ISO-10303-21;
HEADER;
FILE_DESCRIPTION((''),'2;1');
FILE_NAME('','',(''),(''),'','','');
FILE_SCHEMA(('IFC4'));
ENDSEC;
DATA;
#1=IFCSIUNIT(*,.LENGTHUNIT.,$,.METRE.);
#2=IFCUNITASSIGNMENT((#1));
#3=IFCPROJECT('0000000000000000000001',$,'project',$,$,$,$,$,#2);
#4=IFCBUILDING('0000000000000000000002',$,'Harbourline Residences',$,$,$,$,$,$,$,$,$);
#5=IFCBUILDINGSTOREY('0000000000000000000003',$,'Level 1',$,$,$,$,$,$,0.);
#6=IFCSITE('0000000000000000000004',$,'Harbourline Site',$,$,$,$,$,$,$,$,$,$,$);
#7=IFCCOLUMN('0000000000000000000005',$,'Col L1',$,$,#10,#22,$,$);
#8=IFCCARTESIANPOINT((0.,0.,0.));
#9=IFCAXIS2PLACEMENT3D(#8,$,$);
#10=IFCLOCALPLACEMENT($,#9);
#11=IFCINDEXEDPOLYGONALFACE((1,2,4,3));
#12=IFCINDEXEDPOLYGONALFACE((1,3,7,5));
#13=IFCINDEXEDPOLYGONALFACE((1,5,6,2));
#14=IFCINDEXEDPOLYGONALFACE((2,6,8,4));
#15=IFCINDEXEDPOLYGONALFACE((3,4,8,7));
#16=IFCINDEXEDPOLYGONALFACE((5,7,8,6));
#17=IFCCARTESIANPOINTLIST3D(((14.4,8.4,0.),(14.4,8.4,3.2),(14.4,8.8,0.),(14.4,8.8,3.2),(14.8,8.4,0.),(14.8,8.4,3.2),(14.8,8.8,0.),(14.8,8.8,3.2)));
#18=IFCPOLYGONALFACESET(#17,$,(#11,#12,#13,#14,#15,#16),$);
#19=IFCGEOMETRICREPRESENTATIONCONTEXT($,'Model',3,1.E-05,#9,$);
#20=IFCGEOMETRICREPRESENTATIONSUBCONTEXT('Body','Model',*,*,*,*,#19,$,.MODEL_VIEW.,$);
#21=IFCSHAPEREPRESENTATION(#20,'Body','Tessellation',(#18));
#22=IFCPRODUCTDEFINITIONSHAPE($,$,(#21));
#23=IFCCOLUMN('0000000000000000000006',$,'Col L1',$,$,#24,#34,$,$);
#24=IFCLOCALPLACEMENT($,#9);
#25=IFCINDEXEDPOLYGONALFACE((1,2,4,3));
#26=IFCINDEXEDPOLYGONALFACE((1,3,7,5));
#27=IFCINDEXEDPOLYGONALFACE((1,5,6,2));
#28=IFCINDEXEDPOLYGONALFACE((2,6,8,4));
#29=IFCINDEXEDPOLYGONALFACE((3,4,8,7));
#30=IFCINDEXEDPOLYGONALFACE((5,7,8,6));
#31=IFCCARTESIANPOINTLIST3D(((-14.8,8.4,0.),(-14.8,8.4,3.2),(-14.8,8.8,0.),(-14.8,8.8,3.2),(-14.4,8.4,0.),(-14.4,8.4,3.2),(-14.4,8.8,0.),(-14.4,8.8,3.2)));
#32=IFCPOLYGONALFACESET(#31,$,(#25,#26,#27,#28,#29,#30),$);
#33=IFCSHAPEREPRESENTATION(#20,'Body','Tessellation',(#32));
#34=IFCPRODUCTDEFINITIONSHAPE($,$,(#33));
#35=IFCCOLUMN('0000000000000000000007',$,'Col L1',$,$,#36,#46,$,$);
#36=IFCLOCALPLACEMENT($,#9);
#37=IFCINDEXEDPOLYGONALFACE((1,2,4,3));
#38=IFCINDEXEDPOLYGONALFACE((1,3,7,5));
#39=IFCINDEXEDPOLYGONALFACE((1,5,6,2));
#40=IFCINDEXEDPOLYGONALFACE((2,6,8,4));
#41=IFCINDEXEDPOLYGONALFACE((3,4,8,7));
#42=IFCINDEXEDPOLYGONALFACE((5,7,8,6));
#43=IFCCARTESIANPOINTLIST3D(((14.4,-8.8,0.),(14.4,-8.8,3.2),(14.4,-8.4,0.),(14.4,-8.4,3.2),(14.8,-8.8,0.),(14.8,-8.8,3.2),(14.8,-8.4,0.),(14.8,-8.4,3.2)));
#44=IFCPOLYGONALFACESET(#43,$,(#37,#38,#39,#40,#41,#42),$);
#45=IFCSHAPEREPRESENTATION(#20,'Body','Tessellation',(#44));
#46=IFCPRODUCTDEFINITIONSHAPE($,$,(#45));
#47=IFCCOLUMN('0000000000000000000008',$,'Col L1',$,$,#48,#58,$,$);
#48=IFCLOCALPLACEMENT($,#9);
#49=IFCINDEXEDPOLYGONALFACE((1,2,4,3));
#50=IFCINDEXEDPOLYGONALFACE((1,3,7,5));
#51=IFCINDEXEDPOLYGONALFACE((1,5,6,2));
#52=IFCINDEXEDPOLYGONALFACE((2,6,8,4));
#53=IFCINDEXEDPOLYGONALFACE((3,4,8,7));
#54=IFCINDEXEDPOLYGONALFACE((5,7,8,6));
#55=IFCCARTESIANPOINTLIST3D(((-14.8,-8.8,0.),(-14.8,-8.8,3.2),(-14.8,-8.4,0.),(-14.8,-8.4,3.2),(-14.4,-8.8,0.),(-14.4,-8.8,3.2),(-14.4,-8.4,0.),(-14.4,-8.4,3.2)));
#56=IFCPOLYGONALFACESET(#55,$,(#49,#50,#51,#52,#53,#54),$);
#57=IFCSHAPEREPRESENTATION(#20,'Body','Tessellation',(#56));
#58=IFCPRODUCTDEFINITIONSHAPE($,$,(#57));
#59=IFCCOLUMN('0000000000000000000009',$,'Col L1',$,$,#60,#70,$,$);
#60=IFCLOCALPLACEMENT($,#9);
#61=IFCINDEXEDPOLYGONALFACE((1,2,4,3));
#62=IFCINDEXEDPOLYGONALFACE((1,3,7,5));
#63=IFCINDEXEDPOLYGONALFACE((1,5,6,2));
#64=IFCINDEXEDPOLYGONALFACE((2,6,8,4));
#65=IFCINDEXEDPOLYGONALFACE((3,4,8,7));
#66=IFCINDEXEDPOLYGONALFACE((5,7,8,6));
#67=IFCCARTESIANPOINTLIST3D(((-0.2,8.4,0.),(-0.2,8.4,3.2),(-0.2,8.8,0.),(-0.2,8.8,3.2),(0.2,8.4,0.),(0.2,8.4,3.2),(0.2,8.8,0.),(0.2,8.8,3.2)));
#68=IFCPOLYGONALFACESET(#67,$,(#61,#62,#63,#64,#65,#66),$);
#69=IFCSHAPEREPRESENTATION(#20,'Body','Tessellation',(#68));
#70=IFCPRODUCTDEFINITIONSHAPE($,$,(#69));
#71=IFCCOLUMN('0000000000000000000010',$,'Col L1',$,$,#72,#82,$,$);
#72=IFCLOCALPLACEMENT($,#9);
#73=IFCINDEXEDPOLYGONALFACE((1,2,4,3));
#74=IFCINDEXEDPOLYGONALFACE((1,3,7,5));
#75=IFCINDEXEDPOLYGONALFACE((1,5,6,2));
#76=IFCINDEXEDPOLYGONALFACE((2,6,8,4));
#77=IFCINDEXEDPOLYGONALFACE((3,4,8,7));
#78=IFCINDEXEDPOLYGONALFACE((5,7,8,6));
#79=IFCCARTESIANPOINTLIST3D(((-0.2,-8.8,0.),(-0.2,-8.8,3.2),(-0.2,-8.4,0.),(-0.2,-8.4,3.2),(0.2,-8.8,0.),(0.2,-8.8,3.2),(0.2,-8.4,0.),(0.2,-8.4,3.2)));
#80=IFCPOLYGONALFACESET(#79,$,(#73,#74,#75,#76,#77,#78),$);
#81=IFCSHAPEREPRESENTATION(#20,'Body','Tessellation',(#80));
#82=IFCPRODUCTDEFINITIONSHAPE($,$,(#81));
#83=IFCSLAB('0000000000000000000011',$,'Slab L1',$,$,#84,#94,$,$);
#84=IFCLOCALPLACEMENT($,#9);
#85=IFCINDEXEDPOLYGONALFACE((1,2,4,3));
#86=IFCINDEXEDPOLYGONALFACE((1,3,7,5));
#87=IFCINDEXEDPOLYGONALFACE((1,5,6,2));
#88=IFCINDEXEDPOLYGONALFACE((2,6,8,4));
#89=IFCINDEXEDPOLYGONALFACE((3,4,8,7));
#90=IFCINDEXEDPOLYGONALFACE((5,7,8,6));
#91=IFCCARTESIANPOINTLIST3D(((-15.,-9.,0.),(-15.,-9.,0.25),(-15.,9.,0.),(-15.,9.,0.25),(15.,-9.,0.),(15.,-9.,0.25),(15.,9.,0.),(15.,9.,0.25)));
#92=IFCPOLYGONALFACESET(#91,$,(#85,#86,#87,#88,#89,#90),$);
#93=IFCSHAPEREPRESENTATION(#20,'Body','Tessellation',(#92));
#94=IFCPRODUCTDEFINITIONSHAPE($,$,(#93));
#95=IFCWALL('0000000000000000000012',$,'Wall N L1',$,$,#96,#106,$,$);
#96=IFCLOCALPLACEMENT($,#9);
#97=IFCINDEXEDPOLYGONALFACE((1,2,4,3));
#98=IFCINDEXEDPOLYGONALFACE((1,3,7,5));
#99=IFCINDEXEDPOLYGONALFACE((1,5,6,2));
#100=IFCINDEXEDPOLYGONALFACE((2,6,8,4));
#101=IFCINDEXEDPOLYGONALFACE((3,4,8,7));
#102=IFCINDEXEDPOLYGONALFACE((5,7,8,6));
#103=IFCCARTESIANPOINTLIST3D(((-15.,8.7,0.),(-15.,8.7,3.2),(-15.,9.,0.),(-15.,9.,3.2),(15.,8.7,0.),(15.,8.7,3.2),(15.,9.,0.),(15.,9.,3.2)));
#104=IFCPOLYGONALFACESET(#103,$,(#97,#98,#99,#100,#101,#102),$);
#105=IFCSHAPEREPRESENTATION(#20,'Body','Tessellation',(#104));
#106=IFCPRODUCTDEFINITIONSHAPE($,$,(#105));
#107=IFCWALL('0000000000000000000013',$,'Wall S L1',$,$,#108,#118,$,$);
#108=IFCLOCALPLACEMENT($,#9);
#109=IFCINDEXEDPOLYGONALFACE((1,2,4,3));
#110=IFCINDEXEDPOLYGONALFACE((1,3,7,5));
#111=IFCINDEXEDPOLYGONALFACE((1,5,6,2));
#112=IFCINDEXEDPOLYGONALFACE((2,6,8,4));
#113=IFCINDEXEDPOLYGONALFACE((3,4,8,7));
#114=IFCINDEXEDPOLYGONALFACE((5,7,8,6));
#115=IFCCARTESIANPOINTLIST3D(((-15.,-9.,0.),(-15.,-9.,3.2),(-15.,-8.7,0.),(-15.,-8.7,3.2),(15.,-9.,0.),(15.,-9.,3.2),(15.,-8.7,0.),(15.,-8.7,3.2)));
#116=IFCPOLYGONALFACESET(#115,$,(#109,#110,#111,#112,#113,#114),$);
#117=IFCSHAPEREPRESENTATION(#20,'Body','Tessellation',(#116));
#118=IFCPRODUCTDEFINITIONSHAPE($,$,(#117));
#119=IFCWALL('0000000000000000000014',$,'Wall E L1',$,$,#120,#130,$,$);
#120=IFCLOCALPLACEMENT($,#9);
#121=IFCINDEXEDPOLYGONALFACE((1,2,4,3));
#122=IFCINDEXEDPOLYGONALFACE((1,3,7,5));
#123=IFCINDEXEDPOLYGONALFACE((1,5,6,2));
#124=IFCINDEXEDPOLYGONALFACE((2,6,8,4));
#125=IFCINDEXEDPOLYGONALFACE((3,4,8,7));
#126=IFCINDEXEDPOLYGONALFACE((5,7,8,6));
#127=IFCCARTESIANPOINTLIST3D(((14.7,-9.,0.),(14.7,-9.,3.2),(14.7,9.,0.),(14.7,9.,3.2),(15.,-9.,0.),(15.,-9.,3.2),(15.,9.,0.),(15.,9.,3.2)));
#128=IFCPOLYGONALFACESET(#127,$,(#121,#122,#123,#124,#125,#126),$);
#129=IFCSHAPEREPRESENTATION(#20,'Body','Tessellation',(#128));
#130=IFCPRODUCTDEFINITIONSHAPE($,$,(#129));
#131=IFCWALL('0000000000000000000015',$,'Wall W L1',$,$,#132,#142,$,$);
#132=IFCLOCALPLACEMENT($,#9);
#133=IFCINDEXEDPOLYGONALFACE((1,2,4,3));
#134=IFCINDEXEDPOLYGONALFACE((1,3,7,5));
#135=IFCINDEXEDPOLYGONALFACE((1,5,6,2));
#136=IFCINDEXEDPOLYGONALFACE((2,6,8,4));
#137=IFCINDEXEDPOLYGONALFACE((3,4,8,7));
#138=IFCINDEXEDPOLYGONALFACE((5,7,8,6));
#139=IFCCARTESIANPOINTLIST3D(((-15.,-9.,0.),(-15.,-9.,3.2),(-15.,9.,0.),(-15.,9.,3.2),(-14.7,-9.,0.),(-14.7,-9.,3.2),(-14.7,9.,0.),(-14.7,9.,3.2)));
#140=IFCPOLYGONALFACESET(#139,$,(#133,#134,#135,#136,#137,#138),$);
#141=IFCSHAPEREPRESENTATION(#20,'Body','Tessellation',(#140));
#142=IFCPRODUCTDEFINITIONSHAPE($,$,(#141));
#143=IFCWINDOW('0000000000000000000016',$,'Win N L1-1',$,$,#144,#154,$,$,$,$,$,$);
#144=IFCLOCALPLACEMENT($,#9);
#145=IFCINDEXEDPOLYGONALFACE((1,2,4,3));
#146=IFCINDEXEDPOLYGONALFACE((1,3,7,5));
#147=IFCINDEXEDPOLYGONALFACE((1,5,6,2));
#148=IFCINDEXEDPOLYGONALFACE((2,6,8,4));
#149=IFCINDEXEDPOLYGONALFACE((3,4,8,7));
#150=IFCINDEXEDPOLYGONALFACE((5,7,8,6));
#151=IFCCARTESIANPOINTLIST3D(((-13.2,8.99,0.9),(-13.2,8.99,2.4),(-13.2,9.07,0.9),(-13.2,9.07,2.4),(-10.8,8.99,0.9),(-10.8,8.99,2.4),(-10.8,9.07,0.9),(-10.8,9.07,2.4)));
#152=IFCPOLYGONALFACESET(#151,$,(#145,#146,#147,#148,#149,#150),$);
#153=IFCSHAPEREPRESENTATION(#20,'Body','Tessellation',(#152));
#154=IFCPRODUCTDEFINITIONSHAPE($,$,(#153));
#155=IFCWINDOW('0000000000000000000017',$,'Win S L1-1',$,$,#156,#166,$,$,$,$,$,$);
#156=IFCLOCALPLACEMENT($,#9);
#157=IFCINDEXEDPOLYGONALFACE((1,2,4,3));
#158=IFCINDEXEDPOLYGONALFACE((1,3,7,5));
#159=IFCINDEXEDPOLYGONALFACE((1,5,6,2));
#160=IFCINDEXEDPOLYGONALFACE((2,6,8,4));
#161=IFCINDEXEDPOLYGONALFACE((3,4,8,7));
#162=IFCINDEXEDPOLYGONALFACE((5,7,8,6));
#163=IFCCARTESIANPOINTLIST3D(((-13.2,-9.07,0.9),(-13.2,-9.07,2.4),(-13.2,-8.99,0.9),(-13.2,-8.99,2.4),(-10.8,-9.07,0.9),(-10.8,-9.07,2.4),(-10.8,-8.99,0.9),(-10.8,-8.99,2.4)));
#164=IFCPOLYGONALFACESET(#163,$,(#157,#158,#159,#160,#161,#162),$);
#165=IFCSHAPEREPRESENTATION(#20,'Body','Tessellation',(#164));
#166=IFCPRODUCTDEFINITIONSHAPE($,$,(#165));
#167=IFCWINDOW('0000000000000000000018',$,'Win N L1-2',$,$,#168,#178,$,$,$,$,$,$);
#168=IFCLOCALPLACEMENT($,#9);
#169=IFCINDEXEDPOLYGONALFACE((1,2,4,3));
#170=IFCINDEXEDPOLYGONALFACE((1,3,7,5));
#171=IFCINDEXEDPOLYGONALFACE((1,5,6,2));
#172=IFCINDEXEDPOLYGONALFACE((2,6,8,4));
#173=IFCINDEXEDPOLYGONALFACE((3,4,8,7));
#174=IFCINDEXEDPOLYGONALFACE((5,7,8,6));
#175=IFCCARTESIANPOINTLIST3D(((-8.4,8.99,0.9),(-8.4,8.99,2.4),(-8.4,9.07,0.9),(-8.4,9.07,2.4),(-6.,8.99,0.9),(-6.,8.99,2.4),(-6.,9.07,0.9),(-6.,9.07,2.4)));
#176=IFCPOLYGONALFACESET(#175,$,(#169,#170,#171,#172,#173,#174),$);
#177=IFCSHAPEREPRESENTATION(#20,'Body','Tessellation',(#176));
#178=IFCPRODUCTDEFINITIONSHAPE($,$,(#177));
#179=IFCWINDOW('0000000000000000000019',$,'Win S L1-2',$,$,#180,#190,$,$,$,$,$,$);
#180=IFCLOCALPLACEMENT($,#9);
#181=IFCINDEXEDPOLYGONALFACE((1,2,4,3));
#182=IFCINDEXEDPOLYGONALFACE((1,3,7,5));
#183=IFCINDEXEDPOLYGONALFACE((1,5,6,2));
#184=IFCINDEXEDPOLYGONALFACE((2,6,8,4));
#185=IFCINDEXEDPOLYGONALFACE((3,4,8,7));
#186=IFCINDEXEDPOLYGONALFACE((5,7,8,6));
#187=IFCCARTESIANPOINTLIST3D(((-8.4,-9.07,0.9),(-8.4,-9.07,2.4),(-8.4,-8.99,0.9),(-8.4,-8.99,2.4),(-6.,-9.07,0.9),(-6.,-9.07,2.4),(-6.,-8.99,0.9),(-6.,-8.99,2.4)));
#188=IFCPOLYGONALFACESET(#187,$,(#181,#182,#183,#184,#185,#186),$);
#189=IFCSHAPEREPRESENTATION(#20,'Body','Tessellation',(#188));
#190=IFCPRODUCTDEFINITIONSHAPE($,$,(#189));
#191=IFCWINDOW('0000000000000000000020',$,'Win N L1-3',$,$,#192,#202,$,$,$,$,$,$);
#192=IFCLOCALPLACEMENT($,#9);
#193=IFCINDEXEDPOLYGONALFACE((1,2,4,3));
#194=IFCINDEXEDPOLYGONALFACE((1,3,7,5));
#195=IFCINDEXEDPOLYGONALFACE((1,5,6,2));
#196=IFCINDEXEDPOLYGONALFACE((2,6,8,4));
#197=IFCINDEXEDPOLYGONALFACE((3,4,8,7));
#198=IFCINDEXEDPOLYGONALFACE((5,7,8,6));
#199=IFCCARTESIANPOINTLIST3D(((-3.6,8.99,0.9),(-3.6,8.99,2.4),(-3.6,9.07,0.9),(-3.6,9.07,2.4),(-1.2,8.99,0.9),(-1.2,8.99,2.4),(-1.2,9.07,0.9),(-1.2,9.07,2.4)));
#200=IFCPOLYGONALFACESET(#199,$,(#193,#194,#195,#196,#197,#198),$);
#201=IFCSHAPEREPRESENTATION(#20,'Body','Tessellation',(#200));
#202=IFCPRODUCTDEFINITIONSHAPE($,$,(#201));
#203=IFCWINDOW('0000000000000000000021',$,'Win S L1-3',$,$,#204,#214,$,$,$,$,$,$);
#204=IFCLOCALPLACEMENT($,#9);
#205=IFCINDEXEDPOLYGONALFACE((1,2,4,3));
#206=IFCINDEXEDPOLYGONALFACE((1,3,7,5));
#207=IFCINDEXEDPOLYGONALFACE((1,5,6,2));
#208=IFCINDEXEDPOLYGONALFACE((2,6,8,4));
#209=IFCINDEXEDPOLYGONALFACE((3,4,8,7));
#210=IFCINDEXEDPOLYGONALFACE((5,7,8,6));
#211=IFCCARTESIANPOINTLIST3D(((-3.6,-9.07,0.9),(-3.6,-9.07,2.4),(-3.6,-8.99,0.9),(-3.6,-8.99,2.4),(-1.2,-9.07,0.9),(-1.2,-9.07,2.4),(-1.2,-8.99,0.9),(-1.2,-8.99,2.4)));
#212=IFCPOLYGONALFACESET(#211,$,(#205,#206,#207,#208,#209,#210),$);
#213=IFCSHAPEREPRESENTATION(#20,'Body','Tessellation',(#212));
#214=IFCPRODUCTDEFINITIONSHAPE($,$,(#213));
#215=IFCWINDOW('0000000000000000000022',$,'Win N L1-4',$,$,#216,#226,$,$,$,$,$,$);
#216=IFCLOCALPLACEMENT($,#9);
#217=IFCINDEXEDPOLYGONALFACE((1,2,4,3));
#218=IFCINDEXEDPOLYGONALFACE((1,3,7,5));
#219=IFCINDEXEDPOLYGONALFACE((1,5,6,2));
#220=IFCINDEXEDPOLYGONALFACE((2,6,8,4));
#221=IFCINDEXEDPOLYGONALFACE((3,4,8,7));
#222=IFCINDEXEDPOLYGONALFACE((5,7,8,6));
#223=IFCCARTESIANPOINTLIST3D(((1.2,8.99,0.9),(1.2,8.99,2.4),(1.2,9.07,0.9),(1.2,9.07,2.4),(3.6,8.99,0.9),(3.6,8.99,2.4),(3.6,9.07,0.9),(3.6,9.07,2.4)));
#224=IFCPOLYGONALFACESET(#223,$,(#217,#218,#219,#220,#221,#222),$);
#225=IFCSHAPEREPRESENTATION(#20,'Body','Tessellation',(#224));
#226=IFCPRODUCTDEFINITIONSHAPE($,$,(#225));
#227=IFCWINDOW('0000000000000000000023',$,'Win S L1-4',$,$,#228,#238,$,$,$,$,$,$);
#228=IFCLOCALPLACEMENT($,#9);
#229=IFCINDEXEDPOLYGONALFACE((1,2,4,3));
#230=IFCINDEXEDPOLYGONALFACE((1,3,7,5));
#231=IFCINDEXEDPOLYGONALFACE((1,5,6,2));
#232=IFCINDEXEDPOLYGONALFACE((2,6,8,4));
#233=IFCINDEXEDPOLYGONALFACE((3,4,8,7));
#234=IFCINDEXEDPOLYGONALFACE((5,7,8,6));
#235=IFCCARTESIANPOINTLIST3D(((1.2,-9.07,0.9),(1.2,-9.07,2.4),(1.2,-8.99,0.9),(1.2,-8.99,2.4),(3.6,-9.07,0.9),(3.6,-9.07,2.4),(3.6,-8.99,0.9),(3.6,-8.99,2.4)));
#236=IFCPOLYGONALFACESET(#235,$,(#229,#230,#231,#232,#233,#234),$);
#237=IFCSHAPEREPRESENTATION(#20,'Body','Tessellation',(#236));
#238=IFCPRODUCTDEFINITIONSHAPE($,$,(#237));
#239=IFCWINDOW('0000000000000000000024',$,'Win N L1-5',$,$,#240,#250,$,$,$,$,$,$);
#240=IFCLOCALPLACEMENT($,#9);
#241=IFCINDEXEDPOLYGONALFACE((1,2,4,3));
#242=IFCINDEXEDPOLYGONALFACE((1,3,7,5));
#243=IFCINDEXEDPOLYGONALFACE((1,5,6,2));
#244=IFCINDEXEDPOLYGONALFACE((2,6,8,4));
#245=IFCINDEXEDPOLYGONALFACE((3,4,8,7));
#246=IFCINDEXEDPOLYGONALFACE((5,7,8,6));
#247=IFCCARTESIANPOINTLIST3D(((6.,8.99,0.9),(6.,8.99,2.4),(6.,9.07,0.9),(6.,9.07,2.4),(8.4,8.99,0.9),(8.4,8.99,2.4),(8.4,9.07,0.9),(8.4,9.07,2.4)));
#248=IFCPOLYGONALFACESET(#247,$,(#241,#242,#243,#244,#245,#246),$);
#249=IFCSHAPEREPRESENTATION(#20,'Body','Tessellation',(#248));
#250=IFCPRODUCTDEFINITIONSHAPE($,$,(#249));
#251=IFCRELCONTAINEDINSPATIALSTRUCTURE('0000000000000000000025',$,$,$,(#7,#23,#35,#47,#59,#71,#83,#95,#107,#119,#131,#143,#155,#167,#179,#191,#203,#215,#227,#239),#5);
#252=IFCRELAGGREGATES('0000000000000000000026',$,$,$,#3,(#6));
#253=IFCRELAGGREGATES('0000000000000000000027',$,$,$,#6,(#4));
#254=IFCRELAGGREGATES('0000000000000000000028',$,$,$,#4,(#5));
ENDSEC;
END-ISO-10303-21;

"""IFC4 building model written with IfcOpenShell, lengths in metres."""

from ifc_helpers import new_model, si_unit, frame, frame_2d, origin, origin_2d, context, subcontext, project, spatial, rectangle, extrude, element, save


model = new_model("IFC4")

# Units and contexts
model_context = context("Model", 3, precision=1e-05, world=origin())
body_context = subcontext(model_context, "Body", "Model", "MODEL_VIEW")
ifc_project = project(units=[si_unit("LENGTHUNIT", "METRE")])

# Site, building, storey
site = spatial("IfcSite", under=ifc_project, Name="Harbourline Site")
building = spatial("IfcBuilding", under=site, Name="Harbourline Residences")
storey = spatial("IfcBuildingStorey", under=building, Name="Level 1", Elevation=0.0)

# Columns
element("IfcColumn", 1, inside=storey, Name="Col L1", context=body_context, shape_type="SweptSolid", body=[
    extrude(rectangle(XDim=0.4, YDim=0.4, at=frame_2d((14.6, 8.6))), origin(), (0.0, 0.0, 1.0), 3.2),
])
element("IfcColumn", 2, inside=storey, Name="Col L1", context=body_context, shape_type="SweptSolid", body=[
    extrude(rectangle(XDim=0.4, YDim=0.4, at=frame_2d((-14.6, 8.6))), origin(), (0.0, 0.0, 1.0), 3.2),
])
element("IfcColumn", 3, inside=storey, Name="Col L1", context=body_context, shape_type="SweptSolid", body=[
    extrude(rectangle(XDim=0.4, YDim=0.4, at=frame_2d((14.6, -8.6))), origin(), (0.0, 0.0, 1.0), 3.2),
])
element("IfcColumn", 4, inside=storey, Name="Col L1", context=body_context, shape_type="SweptSolid", body=[
    extrude(rectangle(XDim=0.4, YDim=0.4, at=frame_2d((-14.6, -8.6))), origin(), (0.0, 0.0, 1.0), 3.2),
])
element("IfcColumn", 5, inside=storey, Name="Col L1", context=body_context, shape_type="SweptSolid", body=[
    extrude(rectangle(XDim=0.4, YDim=0.4, at=frame_2d((0.0, 8.6))), origin(), (0.0, 0.0, 1.0), 3.2),
])
element("IfcColumn", 6, inside=storey, Name="Col L1", context=body_context, shape_type="SweptSolid", body=[
    extrude(rectangle(XDim=0.4, YDim=0.4, at=frame_2d((0.0, -8.6))), origin(), (0.0, 0.0, 1.0), 3.2),
])

# Slab
element("IfcSlab", 7, inside=storey, Name="Slab L1", context=body_context, shape_type="SweptSolid", body=[
    extrude(rectangle(XDim=30.0, YDim=18.0, at=origin_2d()), origin(), (0.0, 0.0, 1.0), 0.25),
])

# Walls
element("IfcWall", 8, inside=storey, Name="Wall N L1", context=body_context, shape_type="SweptSolid", body=[
    extrude(rectangle(XDim=30.0, YDim=0.3, at=frame_2d((0.0, 8.85))), origin(), (0.0, 0.0, 1.0), 3.2),
])
element("IfcWall", 9, inside=storey, Name="Wall S L1", context=body_context, shape_type="SweptSolid", body=[
    extrude(rectangle(XDim=30.0, YDim=0.3, at=frame_2d((0.0, -8.85))), origin(), (0.0, 0.0, 1.0), 3.2),
])
element("IfcWall", 10, inside=storey, Name="Wall E L1", context=body_context, shape_type="SweptSolid", body=[
    extrude(rectangle(XDim=0.3, YDim=18.0, at=frame_2d((14.85, 0.0))), origin(), (0.0, 0.0, 1.0), 3.2),
])
element("IfcWall", 11, inside=storey, Name="Wall W L1", context=body_context, shape_type="SweptSolid", body=[
    extrude(rectangle(XDim=0.3, YDim=18.0, at=frame_2d((-14.85, 0.0))), origin(), (0.0, 0.0, 1.0), 3.2),
])

# Windows
element("IfcWindow", 12, inside=storey, Name="Win N L1-1", context=body_context, shape_type="SweptSolid", body=[
    extrude(rectangle(XDim=2.4, YDim=0.08, at=frame_2d((-12.0, 9.03))), frame((0.0, 0.0, 0.9)), (0.0, 0.0, 1.0), 1.5),
])
element("IfcWindow", 13, inside=storey, Name="Win S L1-1", context=body_context, shape_type="SweptSolid", body=[
    extrude(rectangle(XDim=2.4, YDim=0.08, at=frame_2d((-12.0, -9.03))), frame((0.0, 0.0, 0.9)), (0.0, 0.0, 1.0), 1.5),
])
element("IfcWindow", 14, inside=storey, Name="Win N L1-2", context=body_context, shape_type="SweptSolid", body=[
    extrude(rectangle(XDim=2.4, YDim=0.08, at=frame_2d((-7.2, 9.03))), frame((0.0, 0.0, 0.9)), (0.0, 0.0, 1.0), 1.5),
])
element("IfcWindow", 15, inside=storey, Name="Win S L1-2", context=body_context, shape_type="SweptSolid", body=[
    extrude(rectangle(XDim=2.4, YDim=0.08, at=frame_2d((-7.2, -9.03))), frame((0.0, 0.0, 0.9)), (0.0, 0.0, 1.0), 1.5),
])
element("IfcWindow", 16, inside=storey, Name="Win N L1-3", context=body_context, shape_type="SweptSolid", body=[
    extrude(rectangle(XDim=2.4, YDim=0.08, at=frame_2d((-2.4, 9.03))), frame((0.0, 0.0, 0.9)), (0.0, 0.0, 1.0), 1.5),
])
element("IfcWindow", 17, inside=storey, Name="Win S L1-3", context=body_context, shape_type="SweptSolid", body=[
    extrude(rectangle(XDim=2.4, YDim=0.08, at=frame_2d((-2.4, -9.03))), frame((0.0, 0.0, 0.9)), (0.0, 0.0, 1.0), 1.5),
])
element("IfcWindow", 18, inside=storey, Name="Win N L1-4", context=body_context, shape_type="SweptSolid", body=[
    extrude(rectangle(XDim=2.4, YDim=0.08, at=frame_2d((2.4, 9.03))), frame((0.0, 0.0, 0.9)), (0.0, 0.0, 1.0), 1.5),
])
element("IfcWindow", 19, inside=storey, Name="Win S L1-4", context=body_context, shape_type="SweptSolid", body=[
    extrude(rectangle(XDim=2.4, YDim=0.08, at=frame_2d((2.4, -9.03))), frame((0.0, 0.0, 0.9)), (0.0, 0.0, 1.0), 1.5),
])
element("IfcWindow", 20, inside=storey, Name="Win N L1-5", context=body_context, shape_type="SweptSolid", body=[
    extrude(rectangle(XDim=2.4, YDim=0.08, at=frame_2d((7.2, 9.03))), frame((0.0, 0.0, 0.9)), (0.0, 0.0, 1.0), 1.5),
])

save(model, "model.ifc")
